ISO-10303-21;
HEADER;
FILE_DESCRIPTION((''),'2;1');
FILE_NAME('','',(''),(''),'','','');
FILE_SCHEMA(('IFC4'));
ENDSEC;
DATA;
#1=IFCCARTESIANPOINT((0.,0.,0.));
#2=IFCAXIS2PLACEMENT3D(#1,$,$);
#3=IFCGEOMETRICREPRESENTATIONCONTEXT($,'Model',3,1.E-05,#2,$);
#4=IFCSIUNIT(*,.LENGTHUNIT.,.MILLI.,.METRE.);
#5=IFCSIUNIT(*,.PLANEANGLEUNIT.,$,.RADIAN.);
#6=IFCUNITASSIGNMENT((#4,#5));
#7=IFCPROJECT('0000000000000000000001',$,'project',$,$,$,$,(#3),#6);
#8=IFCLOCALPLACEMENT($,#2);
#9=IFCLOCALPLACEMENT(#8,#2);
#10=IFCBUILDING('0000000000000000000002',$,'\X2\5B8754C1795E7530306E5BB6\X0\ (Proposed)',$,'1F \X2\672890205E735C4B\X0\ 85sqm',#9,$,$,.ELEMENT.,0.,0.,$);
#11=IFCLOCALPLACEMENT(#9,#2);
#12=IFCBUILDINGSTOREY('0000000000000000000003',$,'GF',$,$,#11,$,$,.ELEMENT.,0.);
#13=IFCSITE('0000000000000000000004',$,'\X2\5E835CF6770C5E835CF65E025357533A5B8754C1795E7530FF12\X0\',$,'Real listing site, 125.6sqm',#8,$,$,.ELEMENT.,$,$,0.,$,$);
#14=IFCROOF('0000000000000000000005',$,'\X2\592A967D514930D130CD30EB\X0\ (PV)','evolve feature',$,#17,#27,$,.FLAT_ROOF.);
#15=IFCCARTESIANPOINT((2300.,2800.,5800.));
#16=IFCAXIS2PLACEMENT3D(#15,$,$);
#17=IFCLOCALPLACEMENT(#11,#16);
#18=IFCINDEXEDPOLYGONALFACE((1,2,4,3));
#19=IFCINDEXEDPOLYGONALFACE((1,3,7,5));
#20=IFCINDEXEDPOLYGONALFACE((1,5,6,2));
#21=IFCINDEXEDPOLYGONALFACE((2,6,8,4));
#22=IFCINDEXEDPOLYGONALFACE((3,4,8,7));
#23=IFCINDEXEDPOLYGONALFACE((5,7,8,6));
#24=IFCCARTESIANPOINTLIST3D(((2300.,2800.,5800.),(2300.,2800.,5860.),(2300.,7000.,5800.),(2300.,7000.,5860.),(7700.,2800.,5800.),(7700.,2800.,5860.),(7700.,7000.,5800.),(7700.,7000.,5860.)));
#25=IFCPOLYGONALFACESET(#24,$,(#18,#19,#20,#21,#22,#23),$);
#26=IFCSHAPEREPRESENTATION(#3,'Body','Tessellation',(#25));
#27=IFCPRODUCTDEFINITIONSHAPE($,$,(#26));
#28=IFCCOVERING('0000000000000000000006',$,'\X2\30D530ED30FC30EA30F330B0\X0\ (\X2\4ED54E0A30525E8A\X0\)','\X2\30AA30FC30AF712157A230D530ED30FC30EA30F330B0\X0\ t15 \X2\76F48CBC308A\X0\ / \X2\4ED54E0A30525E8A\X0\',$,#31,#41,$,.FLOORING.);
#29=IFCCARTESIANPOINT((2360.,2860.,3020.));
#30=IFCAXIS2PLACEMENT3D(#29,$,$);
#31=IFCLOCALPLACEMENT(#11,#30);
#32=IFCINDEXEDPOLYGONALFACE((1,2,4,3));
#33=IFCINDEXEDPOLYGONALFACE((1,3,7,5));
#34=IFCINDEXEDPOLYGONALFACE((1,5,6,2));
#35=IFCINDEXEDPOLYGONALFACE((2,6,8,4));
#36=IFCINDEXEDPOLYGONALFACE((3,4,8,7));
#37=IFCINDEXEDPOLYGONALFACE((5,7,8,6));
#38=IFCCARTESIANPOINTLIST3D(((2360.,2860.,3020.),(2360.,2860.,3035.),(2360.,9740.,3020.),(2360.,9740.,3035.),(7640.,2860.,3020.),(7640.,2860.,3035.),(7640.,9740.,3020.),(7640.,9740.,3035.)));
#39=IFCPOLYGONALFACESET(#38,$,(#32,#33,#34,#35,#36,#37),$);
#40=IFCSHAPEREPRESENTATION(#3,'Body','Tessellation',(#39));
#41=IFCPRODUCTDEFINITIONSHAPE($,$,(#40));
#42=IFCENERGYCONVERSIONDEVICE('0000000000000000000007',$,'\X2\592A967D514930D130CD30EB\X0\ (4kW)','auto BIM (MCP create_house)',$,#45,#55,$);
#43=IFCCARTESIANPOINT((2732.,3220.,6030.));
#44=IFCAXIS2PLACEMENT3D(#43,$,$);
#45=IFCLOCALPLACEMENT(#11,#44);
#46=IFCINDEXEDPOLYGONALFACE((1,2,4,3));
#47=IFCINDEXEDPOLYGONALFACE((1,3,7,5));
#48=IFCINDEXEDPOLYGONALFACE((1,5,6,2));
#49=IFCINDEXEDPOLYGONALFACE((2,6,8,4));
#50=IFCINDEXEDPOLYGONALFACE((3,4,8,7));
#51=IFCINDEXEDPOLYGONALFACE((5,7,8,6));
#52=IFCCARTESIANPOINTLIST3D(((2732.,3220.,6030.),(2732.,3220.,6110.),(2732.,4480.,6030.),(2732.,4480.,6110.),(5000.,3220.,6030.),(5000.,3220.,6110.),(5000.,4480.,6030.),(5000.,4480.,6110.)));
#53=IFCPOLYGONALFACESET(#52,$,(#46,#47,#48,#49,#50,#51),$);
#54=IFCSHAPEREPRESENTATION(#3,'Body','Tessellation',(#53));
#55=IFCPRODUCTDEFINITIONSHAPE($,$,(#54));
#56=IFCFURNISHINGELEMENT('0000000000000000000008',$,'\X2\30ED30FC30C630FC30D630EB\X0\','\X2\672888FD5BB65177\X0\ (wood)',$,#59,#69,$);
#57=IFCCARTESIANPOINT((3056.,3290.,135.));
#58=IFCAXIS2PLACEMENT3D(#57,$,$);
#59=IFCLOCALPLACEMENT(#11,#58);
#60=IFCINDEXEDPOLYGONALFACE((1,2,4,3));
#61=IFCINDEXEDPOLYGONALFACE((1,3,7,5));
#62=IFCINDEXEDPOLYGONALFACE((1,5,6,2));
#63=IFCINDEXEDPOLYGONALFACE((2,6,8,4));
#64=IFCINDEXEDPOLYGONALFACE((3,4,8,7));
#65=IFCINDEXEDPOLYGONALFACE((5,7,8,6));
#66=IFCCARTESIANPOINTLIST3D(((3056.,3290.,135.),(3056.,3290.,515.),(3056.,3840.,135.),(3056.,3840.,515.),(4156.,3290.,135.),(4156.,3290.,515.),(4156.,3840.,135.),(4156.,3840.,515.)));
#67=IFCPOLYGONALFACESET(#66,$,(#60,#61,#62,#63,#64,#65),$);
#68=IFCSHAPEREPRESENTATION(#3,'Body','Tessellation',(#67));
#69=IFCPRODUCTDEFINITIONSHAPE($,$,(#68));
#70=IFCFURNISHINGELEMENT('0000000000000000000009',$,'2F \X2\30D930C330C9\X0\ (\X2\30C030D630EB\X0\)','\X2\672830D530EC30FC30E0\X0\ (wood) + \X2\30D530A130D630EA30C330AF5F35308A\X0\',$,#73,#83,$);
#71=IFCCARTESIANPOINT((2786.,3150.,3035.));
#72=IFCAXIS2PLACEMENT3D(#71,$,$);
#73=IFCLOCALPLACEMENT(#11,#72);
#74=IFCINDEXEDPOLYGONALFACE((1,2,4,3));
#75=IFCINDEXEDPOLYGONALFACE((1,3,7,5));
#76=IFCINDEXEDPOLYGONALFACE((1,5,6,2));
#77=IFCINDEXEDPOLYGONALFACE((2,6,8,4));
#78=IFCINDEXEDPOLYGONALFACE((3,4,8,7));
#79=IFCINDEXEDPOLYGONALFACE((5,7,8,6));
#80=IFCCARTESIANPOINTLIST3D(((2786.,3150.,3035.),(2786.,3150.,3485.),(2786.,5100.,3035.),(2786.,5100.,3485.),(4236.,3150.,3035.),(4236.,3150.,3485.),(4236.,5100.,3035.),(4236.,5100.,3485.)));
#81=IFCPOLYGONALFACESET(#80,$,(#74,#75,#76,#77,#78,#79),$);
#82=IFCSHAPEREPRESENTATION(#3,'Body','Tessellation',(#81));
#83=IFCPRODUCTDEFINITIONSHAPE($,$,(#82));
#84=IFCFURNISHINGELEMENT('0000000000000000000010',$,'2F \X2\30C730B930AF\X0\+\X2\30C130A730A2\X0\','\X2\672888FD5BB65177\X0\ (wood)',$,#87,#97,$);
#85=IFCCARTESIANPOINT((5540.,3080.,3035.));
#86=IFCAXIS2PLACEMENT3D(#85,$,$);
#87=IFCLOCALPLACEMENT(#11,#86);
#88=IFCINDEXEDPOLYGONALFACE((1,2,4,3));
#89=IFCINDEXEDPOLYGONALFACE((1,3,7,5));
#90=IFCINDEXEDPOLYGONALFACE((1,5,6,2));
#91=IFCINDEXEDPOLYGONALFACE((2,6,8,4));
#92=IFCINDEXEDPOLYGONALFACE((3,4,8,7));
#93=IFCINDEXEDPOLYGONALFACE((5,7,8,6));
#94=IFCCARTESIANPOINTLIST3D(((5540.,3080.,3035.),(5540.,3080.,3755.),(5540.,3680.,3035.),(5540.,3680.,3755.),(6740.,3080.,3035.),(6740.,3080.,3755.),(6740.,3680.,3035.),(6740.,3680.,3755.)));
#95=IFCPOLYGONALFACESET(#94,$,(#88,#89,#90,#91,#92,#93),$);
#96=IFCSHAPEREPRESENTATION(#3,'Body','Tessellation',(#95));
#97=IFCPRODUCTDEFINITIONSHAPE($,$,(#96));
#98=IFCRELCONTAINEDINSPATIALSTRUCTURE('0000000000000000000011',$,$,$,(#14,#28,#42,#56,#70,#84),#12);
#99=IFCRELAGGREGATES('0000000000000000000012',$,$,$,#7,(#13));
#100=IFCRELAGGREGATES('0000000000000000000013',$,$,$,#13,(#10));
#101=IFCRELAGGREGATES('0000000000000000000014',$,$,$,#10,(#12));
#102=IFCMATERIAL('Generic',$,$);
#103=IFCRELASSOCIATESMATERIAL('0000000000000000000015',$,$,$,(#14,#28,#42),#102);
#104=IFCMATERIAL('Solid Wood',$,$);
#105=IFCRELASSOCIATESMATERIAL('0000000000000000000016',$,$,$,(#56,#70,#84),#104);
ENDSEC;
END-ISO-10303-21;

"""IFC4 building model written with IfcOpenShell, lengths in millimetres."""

from ifc_helpers import new_model, si_unit, frame, frame_2d, origin, place, context, project, spatial, rectangle, extrude, material, element, save


model = new_model("IFC4")

# Units and contexts
model_context = context("Model", 3, precision=1e-05, world=origin())
ifc_project = project(units=[si_unit("LENGTHUNIT", "METRE", prefix="MILLI"), si_unit("PLANEANGLEUNIT", "RADIAN")], contexts=[model_context])

# Site, building, storey
site_placement = place(None, origin())
site = spatial("IfcSite", under=ifc_project, at=site_placement, Name="広島県広島市南区宇品神田２", ObjectType="Real listing site, 125.6sqm", CompositionType="ELEMENT", RefElevation=0.0)
building_placement = place(site_placement, origin())
building = spatial("IfcBuilding", under=site, at=building_placement, Name="宇品神田の家 (Proposed)", ObjectType="1F 木造平屋 85sqm", CompositionType="ELEMENT", ElevationOfRefHeight=0.0, ElevationOfTerrain=0.0)
storey_placement = place(building_placement, origin())
storey = spatial("IfcBuildingStorey", under=building, at=storey_placement, Name="GF", CompositionType="ELEMENT", Elevation=0.0)

# Shared definitions
ifc_material_1 = material(Name="Solid Wood")

# Shared definitions
ifc_material_2 = material(Name="Generic")

# Roof
roof_1_placement = place(storey_placement, frame((2300.0, 2800.0, 5800.0)))
element("IfcRoof", 1, at=roof_1_placement, inside=storey, material=ifc_material_2, Name="太陽光パネル (PV)", Description="evolve feature", PredefinedType="FLAT_ROOF", context=model_context, shape_type="SweptSolid", body=[
    extrude(rectangle(XDim=5400.0, YDim=4200.0, at=frame_2d((2700.0, 2100.0))), frame((2300.0, 2800.0, 5800.0)), (0.0, 0.0, 1.0), 60.0),
])

# Covering
covering_placement = place(storey_placement, frame((2360.0, 2860.0, 3020.0)))
element("IfcCovering", 2, at=covering_placement, inside=storey, material=ifc_material_2, Name="フローリング (仕上げ床)", Description="オーク無垢フローリング t15 直貼り / 仕上げ床", PredefinedType="FLOORING", context=model_context, shape_type="SweptSolid", body=[
    extrude(rectangle(XDim=5280.0, YDim=6880.0, at=frame_2d((2640.0, 3440.0))), frame((2360.0, 2860.0, 3020.0)), (0.0, 0.0, 1.0), 15.0),
])

# Energy conversion device
energy_conversion_device_placement = place(storey_placement, frame((2732.0, 3220.0, 6030.0)))
element("IfcEnergyConversionDevice", 3, at=energy_conversion_device_placement, inside=storey, material=ifc_material_2, Name="太陽光パネル (4kW)", Description="auto BIM (MCP create_house)", context=model_context, shape_type="SweptSolid", body=[
    extrude(rectangle(XDim=2268.0, YDim=1260.0, at=frame_2d((1134.0, 630.0))), frame((2732.0, 3220.0, 6030.0)), (0.0, 0.0, 1.0), 80.0),
])

# Furnishing elements
furnishing_1_placement = place(storey_placement, frame((3056.0, 3290.0, 135.0)))
element("IfcFurnishingElement", 4, at=furnishing_1_placement, inside=storey, material=ifc_material_1, Name="ローテーブル", Description="木製家具 (wood)", context=model_context, shape_type="SweptSolid", body=[
    extrude(rectangle(XDim=1100.0, YDim=550.0, at=frame_2d((550.0, 275.0))), frame((3056.0, 3290.0, 135.0)), (0.0, 0.0, 1.0), 380.0),
])
furnishing_2_placement = place(storey_placement, frame((2786.0, 3150.0, 3035.0)))
element("IfcFurnishingElement", 5, at=furnishing_2_placement, inside=storey, material=ifc_material_1, Name="2F ベッド (ダブル)", Description="木フレーム (wood) + ファブリック張り", context=model_context, shape_type="SweptSolid", body=[
    extrude(rectangle(XDim=1450.0, YDim=1950.0, at=frame_2d((725.0, 975.0))), frame((2786.0, 3150.0, 3035.0)), (0.0, 0.0, 1.0), 450.0),
])
furnishing_3_placement = place(storey_placement, frame((5540.0, 3080.0, 3035.0)))
element("IfcFurnishingElement", 6, at=furnishing_3_placement, inside=storey, material=ifc_material_1, Name="2F デスク+チェア", Description="木製家具 (wood)", context=model_context, shape_type="SweptSolid", body=[
    extrude(rectangle(XDim=1200.0, YDim=600.0, at=frame_2d((600.0, 300.0))), frame((5540.0, 3080.0, 3035.0)), (0.0, 0.0, 1.0), 720.0),
])

save(model, "model.ifc")
